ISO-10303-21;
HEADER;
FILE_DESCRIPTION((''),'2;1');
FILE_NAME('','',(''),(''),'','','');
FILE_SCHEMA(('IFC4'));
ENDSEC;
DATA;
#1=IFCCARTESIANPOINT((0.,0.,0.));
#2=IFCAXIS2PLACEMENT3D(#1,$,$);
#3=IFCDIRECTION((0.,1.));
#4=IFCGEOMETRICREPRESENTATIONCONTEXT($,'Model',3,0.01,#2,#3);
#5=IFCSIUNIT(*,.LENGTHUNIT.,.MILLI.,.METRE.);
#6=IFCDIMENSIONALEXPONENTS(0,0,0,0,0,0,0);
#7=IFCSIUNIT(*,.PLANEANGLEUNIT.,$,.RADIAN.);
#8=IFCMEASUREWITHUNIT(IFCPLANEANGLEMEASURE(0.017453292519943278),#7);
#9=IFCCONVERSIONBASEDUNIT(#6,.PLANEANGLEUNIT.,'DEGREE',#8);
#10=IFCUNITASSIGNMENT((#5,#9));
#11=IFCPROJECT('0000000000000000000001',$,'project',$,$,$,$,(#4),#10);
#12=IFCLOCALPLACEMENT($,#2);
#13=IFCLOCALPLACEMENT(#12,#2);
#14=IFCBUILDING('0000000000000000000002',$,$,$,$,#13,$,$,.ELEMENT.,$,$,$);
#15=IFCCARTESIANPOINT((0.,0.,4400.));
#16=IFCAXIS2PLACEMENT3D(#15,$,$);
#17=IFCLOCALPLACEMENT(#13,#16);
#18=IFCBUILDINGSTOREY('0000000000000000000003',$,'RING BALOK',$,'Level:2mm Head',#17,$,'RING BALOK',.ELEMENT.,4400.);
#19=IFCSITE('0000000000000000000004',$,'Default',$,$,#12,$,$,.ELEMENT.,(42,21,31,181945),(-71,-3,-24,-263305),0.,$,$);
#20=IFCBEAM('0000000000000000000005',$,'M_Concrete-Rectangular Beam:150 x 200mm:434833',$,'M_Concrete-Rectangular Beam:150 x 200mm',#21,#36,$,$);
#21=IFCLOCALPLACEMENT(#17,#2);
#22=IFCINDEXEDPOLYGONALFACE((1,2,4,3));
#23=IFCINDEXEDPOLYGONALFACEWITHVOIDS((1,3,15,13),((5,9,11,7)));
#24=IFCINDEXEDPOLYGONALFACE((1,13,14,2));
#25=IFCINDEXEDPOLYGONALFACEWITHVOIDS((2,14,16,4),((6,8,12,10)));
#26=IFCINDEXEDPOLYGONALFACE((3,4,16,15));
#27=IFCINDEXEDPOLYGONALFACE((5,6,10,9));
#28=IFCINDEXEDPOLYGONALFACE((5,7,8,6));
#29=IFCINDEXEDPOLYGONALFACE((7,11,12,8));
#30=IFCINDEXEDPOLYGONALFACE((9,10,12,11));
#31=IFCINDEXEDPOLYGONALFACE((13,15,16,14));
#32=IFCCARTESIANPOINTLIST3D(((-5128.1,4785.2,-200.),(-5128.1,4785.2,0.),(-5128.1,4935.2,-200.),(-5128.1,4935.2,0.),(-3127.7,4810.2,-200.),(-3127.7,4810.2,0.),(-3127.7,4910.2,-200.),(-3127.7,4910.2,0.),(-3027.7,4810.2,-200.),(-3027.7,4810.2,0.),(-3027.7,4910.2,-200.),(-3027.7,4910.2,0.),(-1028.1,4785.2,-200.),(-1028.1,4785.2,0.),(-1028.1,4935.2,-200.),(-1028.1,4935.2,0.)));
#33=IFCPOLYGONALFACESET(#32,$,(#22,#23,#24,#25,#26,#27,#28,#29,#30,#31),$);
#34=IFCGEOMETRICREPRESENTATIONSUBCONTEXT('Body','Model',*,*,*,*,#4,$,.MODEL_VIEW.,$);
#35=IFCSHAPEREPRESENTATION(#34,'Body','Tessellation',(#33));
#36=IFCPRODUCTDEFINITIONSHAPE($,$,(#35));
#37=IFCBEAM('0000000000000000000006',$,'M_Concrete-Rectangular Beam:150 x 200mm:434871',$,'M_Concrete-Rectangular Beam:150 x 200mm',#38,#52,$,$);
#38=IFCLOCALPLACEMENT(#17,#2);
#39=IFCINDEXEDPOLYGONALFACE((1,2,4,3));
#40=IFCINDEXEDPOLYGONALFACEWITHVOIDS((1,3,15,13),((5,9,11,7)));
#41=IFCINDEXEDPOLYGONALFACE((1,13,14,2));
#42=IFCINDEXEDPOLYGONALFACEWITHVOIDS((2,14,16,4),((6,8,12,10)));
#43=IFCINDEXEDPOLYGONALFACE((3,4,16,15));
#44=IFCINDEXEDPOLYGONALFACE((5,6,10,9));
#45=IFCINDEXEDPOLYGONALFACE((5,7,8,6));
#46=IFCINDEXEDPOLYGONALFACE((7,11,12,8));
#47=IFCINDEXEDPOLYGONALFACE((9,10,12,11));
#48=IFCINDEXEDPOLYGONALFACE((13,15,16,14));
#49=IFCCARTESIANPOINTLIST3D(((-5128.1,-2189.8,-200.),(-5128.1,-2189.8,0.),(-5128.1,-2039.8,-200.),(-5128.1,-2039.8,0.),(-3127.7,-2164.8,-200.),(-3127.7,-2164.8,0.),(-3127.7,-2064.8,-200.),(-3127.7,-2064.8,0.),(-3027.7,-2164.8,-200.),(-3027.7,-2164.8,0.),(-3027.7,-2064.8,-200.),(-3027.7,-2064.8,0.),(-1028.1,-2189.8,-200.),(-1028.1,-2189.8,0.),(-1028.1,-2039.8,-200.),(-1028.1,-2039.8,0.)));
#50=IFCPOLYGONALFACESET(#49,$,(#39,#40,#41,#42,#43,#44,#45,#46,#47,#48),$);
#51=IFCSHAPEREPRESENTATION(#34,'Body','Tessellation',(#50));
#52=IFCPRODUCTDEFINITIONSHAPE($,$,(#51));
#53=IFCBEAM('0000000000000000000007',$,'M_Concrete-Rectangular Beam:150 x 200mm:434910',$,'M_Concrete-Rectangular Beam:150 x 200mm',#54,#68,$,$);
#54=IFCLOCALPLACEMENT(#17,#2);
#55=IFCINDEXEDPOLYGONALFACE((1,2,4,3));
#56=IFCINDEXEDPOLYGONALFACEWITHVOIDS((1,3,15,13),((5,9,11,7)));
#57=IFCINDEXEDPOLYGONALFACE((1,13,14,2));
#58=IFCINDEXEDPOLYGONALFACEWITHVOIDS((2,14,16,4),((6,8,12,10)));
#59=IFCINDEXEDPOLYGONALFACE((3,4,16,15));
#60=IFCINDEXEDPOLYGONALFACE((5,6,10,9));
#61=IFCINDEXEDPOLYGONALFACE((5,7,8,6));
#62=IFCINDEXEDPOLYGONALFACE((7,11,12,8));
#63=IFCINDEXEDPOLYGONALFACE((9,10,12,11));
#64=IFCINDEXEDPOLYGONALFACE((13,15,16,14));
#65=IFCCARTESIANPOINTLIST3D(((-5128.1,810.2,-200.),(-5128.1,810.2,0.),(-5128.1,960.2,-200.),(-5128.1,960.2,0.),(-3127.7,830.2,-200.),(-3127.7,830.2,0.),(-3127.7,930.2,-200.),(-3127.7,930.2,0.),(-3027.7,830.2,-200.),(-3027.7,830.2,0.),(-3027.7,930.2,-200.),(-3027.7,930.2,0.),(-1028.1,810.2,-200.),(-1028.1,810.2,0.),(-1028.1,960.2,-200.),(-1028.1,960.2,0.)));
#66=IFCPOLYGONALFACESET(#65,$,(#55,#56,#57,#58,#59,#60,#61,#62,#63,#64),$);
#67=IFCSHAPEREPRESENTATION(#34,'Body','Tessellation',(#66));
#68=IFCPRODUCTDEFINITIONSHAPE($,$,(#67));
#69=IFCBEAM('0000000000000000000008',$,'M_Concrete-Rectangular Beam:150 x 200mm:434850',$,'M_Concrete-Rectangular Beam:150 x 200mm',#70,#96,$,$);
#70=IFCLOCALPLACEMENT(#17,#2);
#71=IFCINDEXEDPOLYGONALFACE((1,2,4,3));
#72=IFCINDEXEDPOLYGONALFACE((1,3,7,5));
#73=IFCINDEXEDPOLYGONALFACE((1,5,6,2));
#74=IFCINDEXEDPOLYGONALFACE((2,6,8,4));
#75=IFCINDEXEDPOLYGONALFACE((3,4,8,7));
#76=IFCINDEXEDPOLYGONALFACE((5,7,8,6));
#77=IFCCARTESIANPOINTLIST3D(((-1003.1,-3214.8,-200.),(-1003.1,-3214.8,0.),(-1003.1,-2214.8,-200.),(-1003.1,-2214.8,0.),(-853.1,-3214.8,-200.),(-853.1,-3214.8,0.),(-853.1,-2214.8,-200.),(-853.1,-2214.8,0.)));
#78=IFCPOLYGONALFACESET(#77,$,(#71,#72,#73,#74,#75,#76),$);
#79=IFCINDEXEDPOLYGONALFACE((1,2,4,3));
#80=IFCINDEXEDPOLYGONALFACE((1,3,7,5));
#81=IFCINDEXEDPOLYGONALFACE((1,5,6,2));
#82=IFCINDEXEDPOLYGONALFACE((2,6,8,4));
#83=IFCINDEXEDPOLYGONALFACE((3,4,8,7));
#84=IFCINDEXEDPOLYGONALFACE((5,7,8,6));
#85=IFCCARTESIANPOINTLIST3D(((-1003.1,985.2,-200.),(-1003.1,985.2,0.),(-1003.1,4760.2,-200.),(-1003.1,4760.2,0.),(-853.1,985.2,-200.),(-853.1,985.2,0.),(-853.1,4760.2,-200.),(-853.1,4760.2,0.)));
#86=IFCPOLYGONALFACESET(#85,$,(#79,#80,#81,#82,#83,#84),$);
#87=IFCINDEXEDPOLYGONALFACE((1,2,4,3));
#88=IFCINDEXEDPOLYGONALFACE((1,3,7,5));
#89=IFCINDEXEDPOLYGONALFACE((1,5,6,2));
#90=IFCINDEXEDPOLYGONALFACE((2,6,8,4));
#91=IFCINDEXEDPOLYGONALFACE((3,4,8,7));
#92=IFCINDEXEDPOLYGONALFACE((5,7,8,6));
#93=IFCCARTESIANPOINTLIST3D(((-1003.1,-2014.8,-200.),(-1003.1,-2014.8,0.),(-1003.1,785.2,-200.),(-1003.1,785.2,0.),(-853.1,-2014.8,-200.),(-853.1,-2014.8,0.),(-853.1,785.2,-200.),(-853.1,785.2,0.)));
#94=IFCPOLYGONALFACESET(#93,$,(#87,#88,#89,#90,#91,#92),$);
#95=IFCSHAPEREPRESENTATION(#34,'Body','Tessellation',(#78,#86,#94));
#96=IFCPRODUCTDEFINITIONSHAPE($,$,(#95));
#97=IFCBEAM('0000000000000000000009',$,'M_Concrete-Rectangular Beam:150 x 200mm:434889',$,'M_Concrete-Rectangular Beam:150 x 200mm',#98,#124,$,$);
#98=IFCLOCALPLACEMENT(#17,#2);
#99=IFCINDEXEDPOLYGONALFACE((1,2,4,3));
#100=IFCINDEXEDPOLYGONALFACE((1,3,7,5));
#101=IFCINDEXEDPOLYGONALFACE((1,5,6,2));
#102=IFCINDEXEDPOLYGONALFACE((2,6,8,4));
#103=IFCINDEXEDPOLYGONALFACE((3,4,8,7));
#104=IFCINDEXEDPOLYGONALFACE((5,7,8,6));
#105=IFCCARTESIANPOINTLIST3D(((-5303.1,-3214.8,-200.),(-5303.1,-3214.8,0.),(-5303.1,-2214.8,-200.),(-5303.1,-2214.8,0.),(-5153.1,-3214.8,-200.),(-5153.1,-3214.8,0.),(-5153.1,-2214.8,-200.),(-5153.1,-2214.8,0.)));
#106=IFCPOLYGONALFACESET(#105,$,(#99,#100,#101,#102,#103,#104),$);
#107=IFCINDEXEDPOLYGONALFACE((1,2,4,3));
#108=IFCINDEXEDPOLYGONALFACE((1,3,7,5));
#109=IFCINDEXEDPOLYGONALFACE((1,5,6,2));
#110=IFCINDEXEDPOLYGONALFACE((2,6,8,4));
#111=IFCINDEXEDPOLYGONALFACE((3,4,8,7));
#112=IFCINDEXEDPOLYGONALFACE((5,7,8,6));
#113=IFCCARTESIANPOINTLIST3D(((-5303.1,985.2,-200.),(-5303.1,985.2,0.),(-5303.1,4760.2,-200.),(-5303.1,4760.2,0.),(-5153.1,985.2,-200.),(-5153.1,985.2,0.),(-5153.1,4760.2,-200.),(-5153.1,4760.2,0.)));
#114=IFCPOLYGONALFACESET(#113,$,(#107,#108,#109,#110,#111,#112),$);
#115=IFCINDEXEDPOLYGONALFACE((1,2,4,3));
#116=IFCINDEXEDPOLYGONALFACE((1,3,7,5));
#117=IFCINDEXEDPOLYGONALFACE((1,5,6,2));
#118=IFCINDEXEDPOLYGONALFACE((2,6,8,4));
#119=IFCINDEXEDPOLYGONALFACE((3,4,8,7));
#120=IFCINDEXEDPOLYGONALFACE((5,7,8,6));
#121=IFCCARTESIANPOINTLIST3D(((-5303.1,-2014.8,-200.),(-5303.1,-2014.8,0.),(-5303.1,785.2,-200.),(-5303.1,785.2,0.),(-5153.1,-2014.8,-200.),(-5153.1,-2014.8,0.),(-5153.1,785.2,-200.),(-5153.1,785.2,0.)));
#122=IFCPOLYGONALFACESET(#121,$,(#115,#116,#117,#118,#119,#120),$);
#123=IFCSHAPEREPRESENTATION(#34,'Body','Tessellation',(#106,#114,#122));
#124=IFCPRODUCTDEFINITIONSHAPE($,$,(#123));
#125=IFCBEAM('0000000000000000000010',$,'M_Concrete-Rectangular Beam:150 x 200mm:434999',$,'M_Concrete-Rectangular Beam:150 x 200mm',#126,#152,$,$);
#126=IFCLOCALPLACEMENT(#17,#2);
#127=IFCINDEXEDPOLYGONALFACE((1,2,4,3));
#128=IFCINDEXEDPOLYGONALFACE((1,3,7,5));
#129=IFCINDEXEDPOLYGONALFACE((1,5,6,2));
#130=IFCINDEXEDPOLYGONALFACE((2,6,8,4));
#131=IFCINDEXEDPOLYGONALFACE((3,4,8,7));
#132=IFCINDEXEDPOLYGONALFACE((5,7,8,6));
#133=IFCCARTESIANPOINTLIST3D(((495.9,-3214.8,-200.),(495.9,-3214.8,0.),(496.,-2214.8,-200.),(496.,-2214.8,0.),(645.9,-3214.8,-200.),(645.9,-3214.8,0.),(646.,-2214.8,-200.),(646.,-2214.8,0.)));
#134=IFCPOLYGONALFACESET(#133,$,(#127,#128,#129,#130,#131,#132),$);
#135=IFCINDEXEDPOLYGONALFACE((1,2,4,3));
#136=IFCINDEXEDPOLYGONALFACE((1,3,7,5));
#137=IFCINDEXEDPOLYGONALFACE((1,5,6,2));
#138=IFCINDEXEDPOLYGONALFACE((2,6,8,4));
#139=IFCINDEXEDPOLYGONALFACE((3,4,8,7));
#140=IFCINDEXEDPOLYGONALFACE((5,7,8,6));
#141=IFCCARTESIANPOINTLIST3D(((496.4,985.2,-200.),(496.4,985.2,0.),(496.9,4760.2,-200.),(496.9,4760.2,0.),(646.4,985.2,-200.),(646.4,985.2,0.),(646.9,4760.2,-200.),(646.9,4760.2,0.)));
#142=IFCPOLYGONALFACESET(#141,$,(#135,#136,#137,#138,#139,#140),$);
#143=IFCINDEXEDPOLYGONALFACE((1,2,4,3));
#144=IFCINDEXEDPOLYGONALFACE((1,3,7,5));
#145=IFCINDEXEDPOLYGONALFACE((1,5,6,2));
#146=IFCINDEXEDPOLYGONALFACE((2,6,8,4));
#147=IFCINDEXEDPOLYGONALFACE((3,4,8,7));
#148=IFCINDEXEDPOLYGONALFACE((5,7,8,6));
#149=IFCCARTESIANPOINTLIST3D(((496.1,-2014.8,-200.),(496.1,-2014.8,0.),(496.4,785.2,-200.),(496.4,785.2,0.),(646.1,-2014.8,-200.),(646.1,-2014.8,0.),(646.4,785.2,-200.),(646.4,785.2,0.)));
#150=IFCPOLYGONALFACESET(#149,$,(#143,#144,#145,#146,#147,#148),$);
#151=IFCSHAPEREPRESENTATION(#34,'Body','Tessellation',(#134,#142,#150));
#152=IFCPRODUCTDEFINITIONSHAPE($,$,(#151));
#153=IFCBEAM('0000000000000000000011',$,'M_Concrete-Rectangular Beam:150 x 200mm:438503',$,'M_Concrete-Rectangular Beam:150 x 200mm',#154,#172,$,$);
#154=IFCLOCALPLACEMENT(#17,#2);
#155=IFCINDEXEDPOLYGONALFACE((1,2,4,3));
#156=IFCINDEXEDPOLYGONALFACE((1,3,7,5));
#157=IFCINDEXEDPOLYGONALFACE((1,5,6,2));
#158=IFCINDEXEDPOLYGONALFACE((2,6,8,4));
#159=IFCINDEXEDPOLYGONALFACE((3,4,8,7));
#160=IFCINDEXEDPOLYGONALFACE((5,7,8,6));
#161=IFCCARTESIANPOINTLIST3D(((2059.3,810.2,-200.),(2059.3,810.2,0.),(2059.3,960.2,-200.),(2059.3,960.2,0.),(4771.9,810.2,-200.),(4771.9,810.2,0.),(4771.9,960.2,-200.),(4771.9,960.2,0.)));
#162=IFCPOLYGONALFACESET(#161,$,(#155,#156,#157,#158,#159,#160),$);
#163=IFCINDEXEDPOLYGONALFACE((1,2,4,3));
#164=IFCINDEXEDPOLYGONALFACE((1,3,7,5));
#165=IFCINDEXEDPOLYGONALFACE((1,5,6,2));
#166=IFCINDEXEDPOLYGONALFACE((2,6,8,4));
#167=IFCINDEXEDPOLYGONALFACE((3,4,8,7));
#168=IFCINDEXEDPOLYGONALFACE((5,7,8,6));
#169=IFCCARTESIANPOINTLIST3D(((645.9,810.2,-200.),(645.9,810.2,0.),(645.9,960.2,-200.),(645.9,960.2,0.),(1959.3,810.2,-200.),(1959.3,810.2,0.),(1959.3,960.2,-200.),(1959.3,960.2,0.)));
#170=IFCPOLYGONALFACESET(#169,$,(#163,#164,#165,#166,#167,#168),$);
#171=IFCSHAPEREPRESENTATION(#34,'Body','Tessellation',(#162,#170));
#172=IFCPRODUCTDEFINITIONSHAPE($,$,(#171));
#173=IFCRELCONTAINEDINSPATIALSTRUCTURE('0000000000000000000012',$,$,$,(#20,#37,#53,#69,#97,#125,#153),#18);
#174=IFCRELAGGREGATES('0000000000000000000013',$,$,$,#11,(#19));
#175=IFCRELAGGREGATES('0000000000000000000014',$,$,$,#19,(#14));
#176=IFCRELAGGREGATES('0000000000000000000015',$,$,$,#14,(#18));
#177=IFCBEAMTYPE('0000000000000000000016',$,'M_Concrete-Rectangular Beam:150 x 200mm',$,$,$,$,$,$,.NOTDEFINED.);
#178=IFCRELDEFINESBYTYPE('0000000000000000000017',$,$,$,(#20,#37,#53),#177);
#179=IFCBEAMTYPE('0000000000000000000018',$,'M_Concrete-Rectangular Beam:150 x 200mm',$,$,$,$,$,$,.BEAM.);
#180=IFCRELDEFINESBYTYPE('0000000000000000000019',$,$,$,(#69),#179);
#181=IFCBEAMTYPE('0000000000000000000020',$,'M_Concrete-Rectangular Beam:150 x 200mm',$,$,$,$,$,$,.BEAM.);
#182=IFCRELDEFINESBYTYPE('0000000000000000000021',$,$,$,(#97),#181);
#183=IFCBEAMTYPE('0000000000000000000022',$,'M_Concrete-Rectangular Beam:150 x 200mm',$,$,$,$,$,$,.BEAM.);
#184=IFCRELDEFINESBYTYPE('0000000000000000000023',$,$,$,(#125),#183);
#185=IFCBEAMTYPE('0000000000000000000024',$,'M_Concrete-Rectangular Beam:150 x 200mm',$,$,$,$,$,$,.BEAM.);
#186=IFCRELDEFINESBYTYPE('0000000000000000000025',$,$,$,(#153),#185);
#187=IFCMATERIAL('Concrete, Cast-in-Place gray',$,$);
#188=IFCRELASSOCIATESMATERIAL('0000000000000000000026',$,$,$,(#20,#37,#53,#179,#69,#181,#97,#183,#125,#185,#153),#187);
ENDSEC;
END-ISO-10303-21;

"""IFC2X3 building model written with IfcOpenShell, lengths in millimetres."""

from ifc_helpers import new_model, entity, si_unit, converted_unit, direction, frame, frame_2d, origin, origin_2d_with_axis, place, context, subcontext, project, spatial, rectangle, extrude, boolean, source, transform, mapped, material, type_object, type_shapes, element, save


model = new_model("IFC2X3")

# Units and contexts
model_context = context("Model", 3, precision=0.01, world=origin(), true_north=direction((0.0, 1.0)))
body_context = subcontext(model_context, "Body", "Model", "MODEL_VIEW")
ifc_project = project(units=[si_unit("LENGTHUNIT", "METRE", prefix="MILLI"), converted_unit("PLANEANGLEUNIT", "DEGREE", entity("IfcPlaneAngleMeasure", 0.017453292519943278), si_unit("PLANEANGLEUNIT", "RADIAN"), dimensions=[0, 0, 0, 0, 0, 0, 0])], contexts=[model_context])

# Site, building, storey
site_placement = place(None, origin())
site = spatial("IfcSite", under=ifc_project, at=site_placement, Name="Default", CompositionType="ELEMENT", RefLatitude=(42, 21, 31, 181945), RefLongitude=(-71, -3, -24, -263305), RefElevation=0.0)
building_placement = place(site_placement, origin())
building = spatial("IfcBuilding", under=site, at=building_placement, CompositionType="ELEMENT")
storey_placement = place(building_placement, frame((0.0, 0.0, 4400.0)))
storey = spatial("IfcBuildingStorey", under=building, at=storey_placement, Name="RING BALOK", ObjectType="Level:2mm Head", LongName="RING BALOK", CompositionType="ELEMENT", Elevation=4400.0)

# Shared definitions
ifc_material = material(Name="Concrete, Cast-in-Place gray")

# Beams
beam_type_1 = type_object("IfcBeamType", Name="M_Concrete-Rectangular Beam:150 x 200mm", PredefinedType="NOTDEFINED")
beam_1_placement = place(storey_placement, frame((-5228.1, 4860.2, 0.0)))
element("IfcBeam", 1, at=beam_1_placement, inside=storey, type_object=beam_type_1, material=ifc_material, Name="M_Concrete-Rectangular Beam:150 x 200mm:434833", ObjectType="M_Concrete-Rectangular Beam:150 x 200mm", context=body_context, shape_type="CSG", body=[
    boolean("DIFFERENCE", extrude(rectangle(XDim=200.0, YDim=150.0, at=origin_2d_with_axis()), frame((100.0, 0.0, -100.0), z_axis=(1.0, 0.0, 0.0), x_axis=(0.0, 0.0, -1.0)), (0.0, 0.0, 1.0), 4100.0), extrude(rectangle(XDim=100.0, YDim=100.0, at=origin_2d_with_axis()), frame((2150.4, 0.0, 0.0), z_axis=(0.0, 0.0, -1.0), x_axis=(0.0, -1.0, 0.0)), (0.0, 0.0, 1.0), 200.0)),
])
beam_2_placement = place(storey_placement, frame((-928.1, -2114.8, 0.0), z_axis=(0.0, 0.0, 1.0), x_axis=(-1.0, 0.0, 0.0)))
element("IfcBeam", 2, at=beam_2_placement, inside=storey, type_object=beam_type_1, material=ifc_material, Name="M_Concrete-Rectangular Beam:150 x 200mm:434871", ObjectType="M_Concrete-Rectangular Beam:150 x 200mm", context=body_context, shape_type="CSG", body=[
    boolean("DIFFERENCE", extrude(rectangle(XDim=200.0, YDim=150.0, at=frame_2d((0.0, 0.0), x_axis=(1.0, 0.0))), frame((100.0, 0.0, -100.0), z_axis=(1.0, 0.0, 0.0), x_axis=(0.0, 0.0, -1.0)), (0.0, 0.0, 1.0), 4100.0), extrude(rectangle(XDim=100.0, YDim=100.0, at=frame_2d((0.0, 0.0), x_axis=(1.0, 0.0))), frame((2149.6, 0.0, -200.0), z_axis=(0.0, 0.0, 1.0), x_axis=(0.0, -1.0, 0.0)), (0.0, 0.0, 1.0), 200.0)),
])
beam_3_placement = place(storey_placement, frame((-5228.1, 885.2, 0.0)))
element("IfcBeam", 3, at=beam_3_placement, inside=storey, type_object=beam_type_1, material=ifc_material, Name="M_Concrete-Rectangular Beam:150 x 200mm:434910", ObjectType="M_Concrete-Rectangular Beam:150 x 200mm", context=body_context, shape_type="CSG", body=[
    boolean("DIFFERENCE", extrude(rectangle(XDim=200.0, YDim=150.0, at=frame_2d((0.0, 0.0), x_axis=(1.0, 0.0))), frame((100.0, 0.0, -100.0), z_axis=(1.0, 0.0, 0.0), x_axis=(0.0, 0.0, -1.0)), (0.0, 0.0, 1.0), 4100.0), extrude(rectangle(XDim=100.0, YDim=100.0, at=origin_2d_with_axis()), frame((2150.4, -5.0, 0.0), z_axis=(0.0, 0.0, -1.0), x_axis=(0.0, -1.0, 0.0)), (0.0, 0.0, 1.0), 200.0)),
])
beam_type_2 = type_object("IfcBeamType", Name="M_Concrete-Rectangular Beam:150 x 200mm", PredefinedType="BEAM", material=ifc_material)
shared_shape_1 = source(origin(), body_context, "Body", "SweptSolid", [
    extrude(rectangle(XDim=200.0, YDim=150.0, at=frame_2d((0.0, 0.0), x_axis=(0.0, 1.0))), frame((-928.1, -2214.8, 4300.0), z_axis=(0.0, -1.0, 0.0), x_axis=(-1.0, 0.0, 0.0)), (0.0, 0.0, 1.0), 1000.0),
    extrude(rectangle(XDim=200.0, YDim=150.0, at=frame_2d((0.0, 0.0), x_axis=(0.0, 1.0))), frame((-928.1, 4760.2, 4300.0), z_axis=(0.0, -1.0, 0.0), x_axis=(-1.0, 0.0, 0.0)), (0.0, 0.0, 1.0), 3775.0),
    extrude(rectangle(XDim=200.0, YDim=150.0, at=frame_2d((0.0, 0.0), x_axis=(0.0, 1.0))), frame((-928.1, 785.2, 4300.0), z_axis=(0.0, -1.0, 0.0), x_axis=(-1.0, 0.0, 0.0)), (0.0, 0.0, 1.0), 2800.0),
])
type_shapes(beam_type_2, [shared_shape_1])
beam_4_placement = place(storey_placement, frame((0.0, 0.0, -4400.0)))
element("IfcBeam", 4, at=beam_4_placement, inside=storey, type_object=beam_type_2, material=ifc_material, Name="M_Concrete-Rectangular Beam:150 x 200mm:434850", ObjectType="M_Concrete-Rectangular Beam:150 x 200mm", context=body_context, shape_type="MappedRepresentation", body=[
    mapped(shared_shape_1, transform((0.0, 0.0, 0.0), scale=1.0)),
])
beam_type_3 = type_object("IfcBeamType", Name="M_Concrete-Rectangular Beam:150 x 200mm", PredefinedType="BEAM", material=ifc_material)
shared_shape_2 = source(origin(), body_context, "Body", "SweptSolid", [
    extrude(rectangle(XDim=200.0, YDim=150.0, at=frame_2d((0.0, 0.0), x_axis=(0.0, 1.0))), frame((-5228.1, -3214.8, 4300.0), z_axis=(0.0, 1.0, 0.0), x_axis=(-1.0, 0.0, 0.0)), (0.0, 0.0, 1.0), 1000.0),
    extrude(rectangle(XDim=200.0, YDim=150.0, at=frame_2d((0.0, 0.0), x_axis=(0.0, 1.0))), frame((-5228.1, 985.2, 4300.0), z_axis=(0.0, 1.0, 0.0), x_axis=(-1.0, 0.0, 0.0)), (0.0, 0.0, 1.0), 3775.0),
    extrude(rectangle(XDim=200.0, YDim=150.0, at=frame_2d((0.0, 0.0), x_axis=(0.0, 1.0))), frame((-5228.1, -2014.8, 4300.0), z_axis=(0.0, 1.0, 0.0), x_axis=(-1.0, 0.0, 0.0)), (0.0, 0.0, 1.0), 2800.0),
])
type_shapes(beam_type_3, [shared_shape_2])
beam_5_placement = place(storey_placement, frame((0.0, 0.0, -4400.0)))
element("IfcBeam", 5, at=beam_5_placement, inside=storey, type_object=beam_type_3, material=ifc_material, Name="M_Concrete-Rectangular Beam:150 x 200mm:434889", ObjectType="M_Concrete-Rectangular Beam:150 x 200mm", context=body_context, shape_type="MappedRepresentation", body=[
    mapped(shared_shape_2, transform((0.0, 0.0, 0.0), scale=1.0)),
])
beam_type_4 = type_object("IfcBeamType", Name="M_Concrete-Rectangular Beam:150 x 200mm", PredefinedType="BEAM", material=ifc_material)
shared_shape_3 = source(origin(), body_context, "Body", "SweptSolid", [
    extrude(rectangle(XDim=200.0, YDim=150.0, at=frame_2d((0.0, 0.0), x_axis=(0.0, 1.0))), frame((571.0, -2214.8, 4300.0), z_axis=(-0.000122, -1.0, 0.0), x_axis=(-1.0, 0.000122, 0.0)), (0.0, 0.0, 1.0), 1000.0),
    extrude(rectangle(XDim=200.0, YDim=150.0, at=frame_2d((0.0, 0.0), x_axis=(0.0, 1.0))), frame((571.9, 4760.2, 4300.0), z_axis=(-0.000122, -1.0, 0.0), x_axis=(-1.0, 0.000122, 0.0)), (0.0, 0.0, 1.0), 3775.0),
    extrude(rectangle(XDim=200.0, YDim=150.0, at=frame_2d((0.0, 0.0), x_axis=(0.0, 1.0))), frame((571.4, 785.2, 4300.0), z_axis=(-0.000122, -1.0, 0.0), x_axis=(-1.0, 0.000122, 0.0)), (0.0, 0.0, 1.0), 2800.0),
])
type_shapes(beam_type_4, [shared_shape_3])
beam_6_placement = place(storey_placement, frame((0.0, 0.0, -4400.0)))
element("IfcBeam", 6, at=beam_6_placement, inside=storey, type_object=beam_type_4, material=ifc_material, Name="M_Concrete-Rectangular Beam:150 x 200mm:434999", ObjectType="M_Concrete-Rectangular Beam:150 x 200mm", context=body_context, shape_type="MappedRepresentation", body=[
    mapped(shared_shape_3, transform((0.0, 0.0, 0.0), scale=1.0)),
])
beam_type_5 = type_object("IfcBeamType", Name="M_Concrete-Rectangular Beam:150 x 200mm", PredefinedType="BEAM", material=ifc_material)
shared_shape_4 = source(origin(), body_context, "Body", "SweptSolid", [
    extrude(rectangle(XDim=200.0, YDim=150.0, at=frame_2d((0.0, 0.0), x_axis=(1.0, 0.0))), frame((2059.3, 885.2, 4300.0), z_axis=(1.0, 0.0, 0.0), x_axis=(0.0, 0.0, -1.0)), (0.0, 0.0, 1.0), 2712.6),
    extrude(rectangle(XDim=200.0, YDim=150.0, at=frame_2d((0.0, 0.0), x_axis=(1.0, 0.0))), frame((645.9, 885.2, 4300.0), z_axis=(1.0, 0.0, 0.0), x_axis=(0.0, 0.0, -1.0)), (0.0, 0.0, 1.0), 1313.4),
])
type_shapes(beam_type_5, [shared_shape_4])
beam_7_placement = place(storey_placement, frame((0.0, 0.0, -4400.0)))
element("IfcBeam", 7, at=beam_7_placement, inside=storey, type_object=beam_type_5, material=ifc_material, Name="M_Concrete-Rectangular Beam:150 x 200mm:438503", ObjectType="M_Concrete-Rectangular Beam:150 x 200mm", context=body_context, shape_type="MappedRepresentation", body=[
    mapped(shared_shape_4, transform((0.0, 0.0, 0.0), scale=1.0)),
])

save(model, "model.ifc")
